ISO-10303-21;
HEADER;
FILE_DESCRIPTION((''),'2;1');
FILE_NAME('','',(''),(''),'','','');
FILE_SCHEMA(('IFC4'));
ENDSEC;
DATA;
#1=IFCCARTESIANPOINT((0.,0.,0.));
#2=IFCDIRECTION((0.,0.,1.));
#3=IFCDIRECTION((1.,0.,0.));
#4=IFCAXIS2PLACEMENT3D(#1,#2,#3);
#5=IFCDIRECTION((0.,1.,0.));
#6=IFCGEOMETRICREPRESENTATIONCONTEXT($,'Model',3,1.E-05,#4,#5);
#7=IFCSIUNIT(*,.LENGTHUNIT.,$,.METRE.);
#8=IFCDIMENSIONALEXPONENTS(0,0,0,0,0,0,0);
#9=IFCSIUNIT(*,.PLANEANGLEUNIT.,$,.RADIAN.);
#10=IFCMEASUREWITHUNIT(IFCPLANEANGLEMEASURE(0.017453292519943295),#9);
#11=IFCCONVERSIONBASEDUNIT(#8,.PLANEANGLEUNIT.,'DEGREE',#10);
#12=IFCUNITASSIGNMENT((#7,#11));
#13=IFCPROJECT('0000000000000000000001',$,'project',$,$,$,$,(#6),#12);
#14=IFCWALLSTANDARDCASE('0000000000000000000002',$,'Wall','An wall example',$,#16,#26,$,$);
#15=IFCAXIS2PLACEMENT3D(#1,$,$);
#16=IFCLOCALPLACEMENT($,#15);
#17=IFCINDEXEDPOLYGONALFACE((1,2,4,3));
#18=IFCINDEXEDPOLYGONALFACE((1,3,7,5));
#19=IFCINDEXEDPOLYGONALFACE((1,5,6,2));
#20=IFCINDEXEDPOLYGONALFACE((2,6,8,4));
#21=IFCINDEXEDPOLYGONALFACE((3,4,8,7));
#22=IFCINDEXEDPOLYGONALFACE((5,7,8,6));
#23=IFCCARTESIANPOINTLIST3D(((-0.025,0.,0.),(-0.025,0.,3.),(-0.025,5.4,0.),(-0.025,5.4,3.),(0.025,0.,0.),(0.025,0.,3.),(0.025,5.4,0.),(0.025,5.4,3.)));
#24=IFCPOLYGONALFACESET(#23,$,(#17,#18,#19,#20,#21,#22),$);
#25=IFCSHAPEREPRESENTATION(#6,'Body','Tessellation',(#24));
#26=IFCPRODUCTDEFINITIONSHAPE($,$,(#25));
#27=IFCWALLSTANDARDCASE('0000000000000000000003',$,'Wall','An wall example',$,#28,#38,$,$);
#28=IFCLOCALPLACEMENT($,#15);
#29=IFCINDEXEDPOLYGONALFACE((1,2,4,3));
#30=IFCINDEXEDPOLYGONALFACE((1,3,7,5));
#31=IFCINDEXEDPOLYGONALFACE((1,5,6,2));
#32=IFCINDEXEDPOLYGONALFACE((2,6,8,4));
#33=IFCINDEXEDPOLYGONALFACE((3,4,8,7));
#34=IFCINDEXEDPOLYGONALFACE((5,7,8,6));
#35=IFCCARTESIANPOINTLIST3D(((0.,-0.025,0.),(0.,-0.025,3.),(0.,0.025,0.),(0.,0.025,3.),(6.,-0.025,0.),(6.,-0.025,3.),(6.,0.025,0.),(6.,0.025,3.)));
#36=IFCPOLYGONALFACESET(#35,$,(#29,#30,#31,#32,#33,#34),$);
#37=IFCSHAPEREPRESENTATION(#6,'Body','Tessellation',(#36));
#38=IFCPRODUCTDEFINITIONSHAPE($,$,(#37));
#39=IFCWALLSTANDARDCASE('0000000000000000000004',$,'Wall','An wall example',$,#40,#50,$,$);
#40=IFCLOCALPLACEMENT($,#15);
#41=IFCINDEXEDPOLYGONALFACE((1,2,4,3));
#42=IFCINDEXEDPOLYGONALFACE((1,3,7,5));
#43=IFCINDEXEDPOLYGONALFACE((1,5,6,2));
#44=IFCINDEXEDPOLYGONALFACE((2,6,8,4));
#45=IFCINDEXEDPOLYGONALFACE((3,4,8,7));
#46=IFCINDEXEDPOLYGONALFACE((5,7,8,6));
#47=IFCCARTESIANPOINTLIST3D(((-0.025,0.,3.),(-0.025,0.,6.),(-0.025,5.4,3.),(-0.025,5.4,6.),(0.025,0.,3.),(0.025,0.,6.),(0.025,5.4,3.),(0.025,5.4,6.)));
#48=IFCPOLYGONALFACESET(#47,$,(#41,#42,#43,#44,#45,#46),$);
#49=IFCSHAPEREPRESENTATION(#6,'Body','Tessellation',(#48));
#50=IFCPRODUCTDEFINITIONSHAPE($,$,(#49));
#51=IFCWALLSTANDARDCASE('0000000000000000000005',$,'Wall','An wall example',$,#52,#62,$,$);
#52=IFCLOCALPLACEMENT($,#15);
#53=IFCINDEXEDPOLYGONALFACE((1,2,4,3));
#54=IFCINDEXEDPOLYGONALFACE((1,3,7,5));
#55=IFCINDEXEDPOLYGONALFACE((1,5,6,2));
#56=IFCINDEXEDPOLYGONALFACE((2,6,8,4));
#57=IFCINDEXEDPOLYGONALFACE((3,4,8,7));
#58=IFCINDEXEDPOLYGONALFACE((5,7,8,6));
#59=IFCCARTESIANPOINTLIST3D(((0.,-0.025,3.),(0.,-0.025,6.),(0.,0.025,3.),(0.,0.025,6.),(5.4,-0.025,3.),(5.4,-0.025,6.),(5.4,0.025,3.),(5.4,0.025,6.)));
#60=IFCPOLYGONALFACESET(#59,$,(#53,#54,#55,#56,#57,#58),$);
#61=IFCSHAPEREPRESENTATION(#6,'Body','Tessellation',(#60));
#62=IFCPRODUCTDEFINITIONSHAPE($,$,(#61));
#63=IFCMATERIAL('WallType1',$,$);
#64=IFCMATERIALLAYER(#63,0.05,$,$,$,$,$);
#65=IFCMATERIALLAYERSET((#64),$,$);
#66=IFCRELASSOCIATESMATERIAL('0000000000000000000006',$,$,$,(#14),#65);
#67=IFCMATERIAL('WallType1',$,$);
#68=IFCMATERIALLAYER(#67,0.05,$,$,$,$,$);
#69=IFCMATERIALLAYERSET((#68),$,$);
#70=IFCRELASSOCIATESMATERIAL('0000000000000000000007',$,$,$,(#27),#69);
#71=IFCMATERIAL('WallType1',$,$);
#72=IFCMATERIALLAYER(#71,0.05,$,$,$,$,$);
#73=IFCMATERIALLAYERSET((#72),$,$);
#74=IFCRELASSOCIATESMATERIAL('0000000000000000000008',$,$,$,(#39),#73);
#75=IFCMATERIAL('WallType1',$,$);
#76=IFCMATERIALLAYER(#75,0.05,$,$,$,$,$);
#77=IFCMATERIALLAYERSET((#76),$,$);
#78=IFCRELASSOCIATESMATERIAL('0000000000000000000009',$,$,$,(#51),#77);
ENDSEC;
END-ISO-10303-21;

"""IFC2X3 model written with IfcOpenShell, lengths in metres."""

from ifc_helpers import new_model, entity, si_unit, converted_unit, direction, frame, origin_with_axes, place, context, project, polyline, outline, extrude, material, layer, layer_set, layer_usage, element, save


model = new_model("IFC2X3")

# Units and contexts
model_context = context("Model", 3, precision=1e-05, world=origin_with_axes(), true_north=direction((0.0, 1.0, 0.0)))
ifc_project = project(units=[si_unit("LENGTHUNIT", "METRE"), converted_unit("PLANEANGLEUNIT", "DEGREE", entity("IfcPlaneAngleMeasure", 0.017453292519943295), si_unit("PLANEANGLEUNIT", "RADIAN"), dimensions=[0, 0, 0, 0, 0, 0, 0])], contexts=[model_context])

# Walls
ifc_material_1 = material(Name="WallType1")
ifc_layer_1 = layer(ifc_material_1, 0.05)
ifc_layer_set_1 = layer_set([ifc_layer_1])
ifc_layer_usage_1 = layer_usage(ifc_layer_set_1, "AXIS2", "POSITIVE", -0.1)
placement_1 = place(None, origin_with_axes())
placement_2 = place(placement_1, origin_with_axes())
placement_3 = place(placement_2, origin_with_axes())
wall_1_placement = place(placement_3, origin_with_axes())
element("IfcWallStandardCase", 1, at=wall_1_placement, material=ifc_layer_usage_1, Name="Wall", Description="An wall example", context=model_context, shape_type="SweptSolid", body=[
    extrude(outline(polyline([(-0.025, 0.0, 0.0), (-0.025, 5.4, 0.0), (0.025, 5.4, 0.0), (0.025, 0.0, 0.0), (-0.025, 0.0, 0.0)])), origin_with_axes(), (0.0, 0.0, 1.0), 3.0),
])
ifc_material_2 = material(Name="WallType1")
ifc_layer_2 = layer(ifc_material_2, 0.05)
ifc_layer_set_2 = layer_set([ifc_layer_2])
ifc_layer_usage_2 = layer_usage(ifc_layer_set_2, "AXIS2", "POSITIVE", -0.1)
wall_2_placement = place(placement_3, origin_with_axes())
element("IfcWallStandardCase", 2, at=wall_2_placement, material=ifc_layer_usage_2, Name="Wall", Description="An wall example", context=model_context, shape_type="SweptSolid", body=[
    extrude(outline(polyline([(0.0, 0.025, 0.0), (6.0, 0.025, 0.0), (6.0, -0.025, 0.0), (0.0, -0.025, 0.0), (0.0, 0.025, 0.0)])), origin_with_axes(), (0.0, 0.0, 1.0), 3.0),
])
ifc_material_3 = material(Name="WallType1")
ifc_layer_3 = layer(ifc_material_3, 0.05)
ifc_layer_set_3 = layer_set([ifc_layer_3])
ifc_layer_usage_3 = layer_usage(ifc_layer_set_3, "AXIS2", "POSITIVE", -0.1)
wall_3_placement = place(placement_3, origin_with_axes())
element("IfcWallStandardCase", 3, at=wall_3_placement, material=ifc_layer_usage_3, Name="Wall", Description="An wall example", context=model_context, shape_type="SweptSolid", body=[
    extrude(outline(polyline([(-0.025, 0.0, 1.5), (-0.025, 5.4, 1.5), (0.025, 5.4, 1.5), (0.025, 0.0, 1.5), (-0.025, 0.0, 1.5)])), frame((0.0, 0.0, 1.5), z_axis=(0.0, 0.0, 1.0), x_axis=(1.0, 0.0, 0.0)), (0.0, 0.0, 1.0), 3.0),
])
ifc_material_4 = material(Name="WallType1")
ifc_layer_4 = layer(ifc_material_4, 0.05)
ifc_layer_set_4 = layer_set([ifc_layer_4])
ifc_layer_usage_4 = layer_usage(ifc_layer_set_4, "AXIS2", "POSITIVE", -0.1)
wall_4_placement = place(placement_3, origin_with_axes())
element("IfcWallStandardCase", 4, at=wall_4_placement, material=ifc_layer_usage_4, Name="Wall", Description="An wall example", context=model_context, shape_type="SweptSolid", body=[
    extrude(outline(polyline([(0.0, 0.025, 1.5), (5.4, 0.025, 1.5), (5.4, -0.025, 1.5), (0.0, -0.025, 1.5), (0.0, 0.025, 1.5)])), frame((0.0, 0.0, 1.5), z_axis=(0.0, 0.0, 1.0), x_axis=(1.0, 0.0, 0.0)), (0.0, 0.0, 1.0), 3.0),
])

save(model, "model.ifc")
